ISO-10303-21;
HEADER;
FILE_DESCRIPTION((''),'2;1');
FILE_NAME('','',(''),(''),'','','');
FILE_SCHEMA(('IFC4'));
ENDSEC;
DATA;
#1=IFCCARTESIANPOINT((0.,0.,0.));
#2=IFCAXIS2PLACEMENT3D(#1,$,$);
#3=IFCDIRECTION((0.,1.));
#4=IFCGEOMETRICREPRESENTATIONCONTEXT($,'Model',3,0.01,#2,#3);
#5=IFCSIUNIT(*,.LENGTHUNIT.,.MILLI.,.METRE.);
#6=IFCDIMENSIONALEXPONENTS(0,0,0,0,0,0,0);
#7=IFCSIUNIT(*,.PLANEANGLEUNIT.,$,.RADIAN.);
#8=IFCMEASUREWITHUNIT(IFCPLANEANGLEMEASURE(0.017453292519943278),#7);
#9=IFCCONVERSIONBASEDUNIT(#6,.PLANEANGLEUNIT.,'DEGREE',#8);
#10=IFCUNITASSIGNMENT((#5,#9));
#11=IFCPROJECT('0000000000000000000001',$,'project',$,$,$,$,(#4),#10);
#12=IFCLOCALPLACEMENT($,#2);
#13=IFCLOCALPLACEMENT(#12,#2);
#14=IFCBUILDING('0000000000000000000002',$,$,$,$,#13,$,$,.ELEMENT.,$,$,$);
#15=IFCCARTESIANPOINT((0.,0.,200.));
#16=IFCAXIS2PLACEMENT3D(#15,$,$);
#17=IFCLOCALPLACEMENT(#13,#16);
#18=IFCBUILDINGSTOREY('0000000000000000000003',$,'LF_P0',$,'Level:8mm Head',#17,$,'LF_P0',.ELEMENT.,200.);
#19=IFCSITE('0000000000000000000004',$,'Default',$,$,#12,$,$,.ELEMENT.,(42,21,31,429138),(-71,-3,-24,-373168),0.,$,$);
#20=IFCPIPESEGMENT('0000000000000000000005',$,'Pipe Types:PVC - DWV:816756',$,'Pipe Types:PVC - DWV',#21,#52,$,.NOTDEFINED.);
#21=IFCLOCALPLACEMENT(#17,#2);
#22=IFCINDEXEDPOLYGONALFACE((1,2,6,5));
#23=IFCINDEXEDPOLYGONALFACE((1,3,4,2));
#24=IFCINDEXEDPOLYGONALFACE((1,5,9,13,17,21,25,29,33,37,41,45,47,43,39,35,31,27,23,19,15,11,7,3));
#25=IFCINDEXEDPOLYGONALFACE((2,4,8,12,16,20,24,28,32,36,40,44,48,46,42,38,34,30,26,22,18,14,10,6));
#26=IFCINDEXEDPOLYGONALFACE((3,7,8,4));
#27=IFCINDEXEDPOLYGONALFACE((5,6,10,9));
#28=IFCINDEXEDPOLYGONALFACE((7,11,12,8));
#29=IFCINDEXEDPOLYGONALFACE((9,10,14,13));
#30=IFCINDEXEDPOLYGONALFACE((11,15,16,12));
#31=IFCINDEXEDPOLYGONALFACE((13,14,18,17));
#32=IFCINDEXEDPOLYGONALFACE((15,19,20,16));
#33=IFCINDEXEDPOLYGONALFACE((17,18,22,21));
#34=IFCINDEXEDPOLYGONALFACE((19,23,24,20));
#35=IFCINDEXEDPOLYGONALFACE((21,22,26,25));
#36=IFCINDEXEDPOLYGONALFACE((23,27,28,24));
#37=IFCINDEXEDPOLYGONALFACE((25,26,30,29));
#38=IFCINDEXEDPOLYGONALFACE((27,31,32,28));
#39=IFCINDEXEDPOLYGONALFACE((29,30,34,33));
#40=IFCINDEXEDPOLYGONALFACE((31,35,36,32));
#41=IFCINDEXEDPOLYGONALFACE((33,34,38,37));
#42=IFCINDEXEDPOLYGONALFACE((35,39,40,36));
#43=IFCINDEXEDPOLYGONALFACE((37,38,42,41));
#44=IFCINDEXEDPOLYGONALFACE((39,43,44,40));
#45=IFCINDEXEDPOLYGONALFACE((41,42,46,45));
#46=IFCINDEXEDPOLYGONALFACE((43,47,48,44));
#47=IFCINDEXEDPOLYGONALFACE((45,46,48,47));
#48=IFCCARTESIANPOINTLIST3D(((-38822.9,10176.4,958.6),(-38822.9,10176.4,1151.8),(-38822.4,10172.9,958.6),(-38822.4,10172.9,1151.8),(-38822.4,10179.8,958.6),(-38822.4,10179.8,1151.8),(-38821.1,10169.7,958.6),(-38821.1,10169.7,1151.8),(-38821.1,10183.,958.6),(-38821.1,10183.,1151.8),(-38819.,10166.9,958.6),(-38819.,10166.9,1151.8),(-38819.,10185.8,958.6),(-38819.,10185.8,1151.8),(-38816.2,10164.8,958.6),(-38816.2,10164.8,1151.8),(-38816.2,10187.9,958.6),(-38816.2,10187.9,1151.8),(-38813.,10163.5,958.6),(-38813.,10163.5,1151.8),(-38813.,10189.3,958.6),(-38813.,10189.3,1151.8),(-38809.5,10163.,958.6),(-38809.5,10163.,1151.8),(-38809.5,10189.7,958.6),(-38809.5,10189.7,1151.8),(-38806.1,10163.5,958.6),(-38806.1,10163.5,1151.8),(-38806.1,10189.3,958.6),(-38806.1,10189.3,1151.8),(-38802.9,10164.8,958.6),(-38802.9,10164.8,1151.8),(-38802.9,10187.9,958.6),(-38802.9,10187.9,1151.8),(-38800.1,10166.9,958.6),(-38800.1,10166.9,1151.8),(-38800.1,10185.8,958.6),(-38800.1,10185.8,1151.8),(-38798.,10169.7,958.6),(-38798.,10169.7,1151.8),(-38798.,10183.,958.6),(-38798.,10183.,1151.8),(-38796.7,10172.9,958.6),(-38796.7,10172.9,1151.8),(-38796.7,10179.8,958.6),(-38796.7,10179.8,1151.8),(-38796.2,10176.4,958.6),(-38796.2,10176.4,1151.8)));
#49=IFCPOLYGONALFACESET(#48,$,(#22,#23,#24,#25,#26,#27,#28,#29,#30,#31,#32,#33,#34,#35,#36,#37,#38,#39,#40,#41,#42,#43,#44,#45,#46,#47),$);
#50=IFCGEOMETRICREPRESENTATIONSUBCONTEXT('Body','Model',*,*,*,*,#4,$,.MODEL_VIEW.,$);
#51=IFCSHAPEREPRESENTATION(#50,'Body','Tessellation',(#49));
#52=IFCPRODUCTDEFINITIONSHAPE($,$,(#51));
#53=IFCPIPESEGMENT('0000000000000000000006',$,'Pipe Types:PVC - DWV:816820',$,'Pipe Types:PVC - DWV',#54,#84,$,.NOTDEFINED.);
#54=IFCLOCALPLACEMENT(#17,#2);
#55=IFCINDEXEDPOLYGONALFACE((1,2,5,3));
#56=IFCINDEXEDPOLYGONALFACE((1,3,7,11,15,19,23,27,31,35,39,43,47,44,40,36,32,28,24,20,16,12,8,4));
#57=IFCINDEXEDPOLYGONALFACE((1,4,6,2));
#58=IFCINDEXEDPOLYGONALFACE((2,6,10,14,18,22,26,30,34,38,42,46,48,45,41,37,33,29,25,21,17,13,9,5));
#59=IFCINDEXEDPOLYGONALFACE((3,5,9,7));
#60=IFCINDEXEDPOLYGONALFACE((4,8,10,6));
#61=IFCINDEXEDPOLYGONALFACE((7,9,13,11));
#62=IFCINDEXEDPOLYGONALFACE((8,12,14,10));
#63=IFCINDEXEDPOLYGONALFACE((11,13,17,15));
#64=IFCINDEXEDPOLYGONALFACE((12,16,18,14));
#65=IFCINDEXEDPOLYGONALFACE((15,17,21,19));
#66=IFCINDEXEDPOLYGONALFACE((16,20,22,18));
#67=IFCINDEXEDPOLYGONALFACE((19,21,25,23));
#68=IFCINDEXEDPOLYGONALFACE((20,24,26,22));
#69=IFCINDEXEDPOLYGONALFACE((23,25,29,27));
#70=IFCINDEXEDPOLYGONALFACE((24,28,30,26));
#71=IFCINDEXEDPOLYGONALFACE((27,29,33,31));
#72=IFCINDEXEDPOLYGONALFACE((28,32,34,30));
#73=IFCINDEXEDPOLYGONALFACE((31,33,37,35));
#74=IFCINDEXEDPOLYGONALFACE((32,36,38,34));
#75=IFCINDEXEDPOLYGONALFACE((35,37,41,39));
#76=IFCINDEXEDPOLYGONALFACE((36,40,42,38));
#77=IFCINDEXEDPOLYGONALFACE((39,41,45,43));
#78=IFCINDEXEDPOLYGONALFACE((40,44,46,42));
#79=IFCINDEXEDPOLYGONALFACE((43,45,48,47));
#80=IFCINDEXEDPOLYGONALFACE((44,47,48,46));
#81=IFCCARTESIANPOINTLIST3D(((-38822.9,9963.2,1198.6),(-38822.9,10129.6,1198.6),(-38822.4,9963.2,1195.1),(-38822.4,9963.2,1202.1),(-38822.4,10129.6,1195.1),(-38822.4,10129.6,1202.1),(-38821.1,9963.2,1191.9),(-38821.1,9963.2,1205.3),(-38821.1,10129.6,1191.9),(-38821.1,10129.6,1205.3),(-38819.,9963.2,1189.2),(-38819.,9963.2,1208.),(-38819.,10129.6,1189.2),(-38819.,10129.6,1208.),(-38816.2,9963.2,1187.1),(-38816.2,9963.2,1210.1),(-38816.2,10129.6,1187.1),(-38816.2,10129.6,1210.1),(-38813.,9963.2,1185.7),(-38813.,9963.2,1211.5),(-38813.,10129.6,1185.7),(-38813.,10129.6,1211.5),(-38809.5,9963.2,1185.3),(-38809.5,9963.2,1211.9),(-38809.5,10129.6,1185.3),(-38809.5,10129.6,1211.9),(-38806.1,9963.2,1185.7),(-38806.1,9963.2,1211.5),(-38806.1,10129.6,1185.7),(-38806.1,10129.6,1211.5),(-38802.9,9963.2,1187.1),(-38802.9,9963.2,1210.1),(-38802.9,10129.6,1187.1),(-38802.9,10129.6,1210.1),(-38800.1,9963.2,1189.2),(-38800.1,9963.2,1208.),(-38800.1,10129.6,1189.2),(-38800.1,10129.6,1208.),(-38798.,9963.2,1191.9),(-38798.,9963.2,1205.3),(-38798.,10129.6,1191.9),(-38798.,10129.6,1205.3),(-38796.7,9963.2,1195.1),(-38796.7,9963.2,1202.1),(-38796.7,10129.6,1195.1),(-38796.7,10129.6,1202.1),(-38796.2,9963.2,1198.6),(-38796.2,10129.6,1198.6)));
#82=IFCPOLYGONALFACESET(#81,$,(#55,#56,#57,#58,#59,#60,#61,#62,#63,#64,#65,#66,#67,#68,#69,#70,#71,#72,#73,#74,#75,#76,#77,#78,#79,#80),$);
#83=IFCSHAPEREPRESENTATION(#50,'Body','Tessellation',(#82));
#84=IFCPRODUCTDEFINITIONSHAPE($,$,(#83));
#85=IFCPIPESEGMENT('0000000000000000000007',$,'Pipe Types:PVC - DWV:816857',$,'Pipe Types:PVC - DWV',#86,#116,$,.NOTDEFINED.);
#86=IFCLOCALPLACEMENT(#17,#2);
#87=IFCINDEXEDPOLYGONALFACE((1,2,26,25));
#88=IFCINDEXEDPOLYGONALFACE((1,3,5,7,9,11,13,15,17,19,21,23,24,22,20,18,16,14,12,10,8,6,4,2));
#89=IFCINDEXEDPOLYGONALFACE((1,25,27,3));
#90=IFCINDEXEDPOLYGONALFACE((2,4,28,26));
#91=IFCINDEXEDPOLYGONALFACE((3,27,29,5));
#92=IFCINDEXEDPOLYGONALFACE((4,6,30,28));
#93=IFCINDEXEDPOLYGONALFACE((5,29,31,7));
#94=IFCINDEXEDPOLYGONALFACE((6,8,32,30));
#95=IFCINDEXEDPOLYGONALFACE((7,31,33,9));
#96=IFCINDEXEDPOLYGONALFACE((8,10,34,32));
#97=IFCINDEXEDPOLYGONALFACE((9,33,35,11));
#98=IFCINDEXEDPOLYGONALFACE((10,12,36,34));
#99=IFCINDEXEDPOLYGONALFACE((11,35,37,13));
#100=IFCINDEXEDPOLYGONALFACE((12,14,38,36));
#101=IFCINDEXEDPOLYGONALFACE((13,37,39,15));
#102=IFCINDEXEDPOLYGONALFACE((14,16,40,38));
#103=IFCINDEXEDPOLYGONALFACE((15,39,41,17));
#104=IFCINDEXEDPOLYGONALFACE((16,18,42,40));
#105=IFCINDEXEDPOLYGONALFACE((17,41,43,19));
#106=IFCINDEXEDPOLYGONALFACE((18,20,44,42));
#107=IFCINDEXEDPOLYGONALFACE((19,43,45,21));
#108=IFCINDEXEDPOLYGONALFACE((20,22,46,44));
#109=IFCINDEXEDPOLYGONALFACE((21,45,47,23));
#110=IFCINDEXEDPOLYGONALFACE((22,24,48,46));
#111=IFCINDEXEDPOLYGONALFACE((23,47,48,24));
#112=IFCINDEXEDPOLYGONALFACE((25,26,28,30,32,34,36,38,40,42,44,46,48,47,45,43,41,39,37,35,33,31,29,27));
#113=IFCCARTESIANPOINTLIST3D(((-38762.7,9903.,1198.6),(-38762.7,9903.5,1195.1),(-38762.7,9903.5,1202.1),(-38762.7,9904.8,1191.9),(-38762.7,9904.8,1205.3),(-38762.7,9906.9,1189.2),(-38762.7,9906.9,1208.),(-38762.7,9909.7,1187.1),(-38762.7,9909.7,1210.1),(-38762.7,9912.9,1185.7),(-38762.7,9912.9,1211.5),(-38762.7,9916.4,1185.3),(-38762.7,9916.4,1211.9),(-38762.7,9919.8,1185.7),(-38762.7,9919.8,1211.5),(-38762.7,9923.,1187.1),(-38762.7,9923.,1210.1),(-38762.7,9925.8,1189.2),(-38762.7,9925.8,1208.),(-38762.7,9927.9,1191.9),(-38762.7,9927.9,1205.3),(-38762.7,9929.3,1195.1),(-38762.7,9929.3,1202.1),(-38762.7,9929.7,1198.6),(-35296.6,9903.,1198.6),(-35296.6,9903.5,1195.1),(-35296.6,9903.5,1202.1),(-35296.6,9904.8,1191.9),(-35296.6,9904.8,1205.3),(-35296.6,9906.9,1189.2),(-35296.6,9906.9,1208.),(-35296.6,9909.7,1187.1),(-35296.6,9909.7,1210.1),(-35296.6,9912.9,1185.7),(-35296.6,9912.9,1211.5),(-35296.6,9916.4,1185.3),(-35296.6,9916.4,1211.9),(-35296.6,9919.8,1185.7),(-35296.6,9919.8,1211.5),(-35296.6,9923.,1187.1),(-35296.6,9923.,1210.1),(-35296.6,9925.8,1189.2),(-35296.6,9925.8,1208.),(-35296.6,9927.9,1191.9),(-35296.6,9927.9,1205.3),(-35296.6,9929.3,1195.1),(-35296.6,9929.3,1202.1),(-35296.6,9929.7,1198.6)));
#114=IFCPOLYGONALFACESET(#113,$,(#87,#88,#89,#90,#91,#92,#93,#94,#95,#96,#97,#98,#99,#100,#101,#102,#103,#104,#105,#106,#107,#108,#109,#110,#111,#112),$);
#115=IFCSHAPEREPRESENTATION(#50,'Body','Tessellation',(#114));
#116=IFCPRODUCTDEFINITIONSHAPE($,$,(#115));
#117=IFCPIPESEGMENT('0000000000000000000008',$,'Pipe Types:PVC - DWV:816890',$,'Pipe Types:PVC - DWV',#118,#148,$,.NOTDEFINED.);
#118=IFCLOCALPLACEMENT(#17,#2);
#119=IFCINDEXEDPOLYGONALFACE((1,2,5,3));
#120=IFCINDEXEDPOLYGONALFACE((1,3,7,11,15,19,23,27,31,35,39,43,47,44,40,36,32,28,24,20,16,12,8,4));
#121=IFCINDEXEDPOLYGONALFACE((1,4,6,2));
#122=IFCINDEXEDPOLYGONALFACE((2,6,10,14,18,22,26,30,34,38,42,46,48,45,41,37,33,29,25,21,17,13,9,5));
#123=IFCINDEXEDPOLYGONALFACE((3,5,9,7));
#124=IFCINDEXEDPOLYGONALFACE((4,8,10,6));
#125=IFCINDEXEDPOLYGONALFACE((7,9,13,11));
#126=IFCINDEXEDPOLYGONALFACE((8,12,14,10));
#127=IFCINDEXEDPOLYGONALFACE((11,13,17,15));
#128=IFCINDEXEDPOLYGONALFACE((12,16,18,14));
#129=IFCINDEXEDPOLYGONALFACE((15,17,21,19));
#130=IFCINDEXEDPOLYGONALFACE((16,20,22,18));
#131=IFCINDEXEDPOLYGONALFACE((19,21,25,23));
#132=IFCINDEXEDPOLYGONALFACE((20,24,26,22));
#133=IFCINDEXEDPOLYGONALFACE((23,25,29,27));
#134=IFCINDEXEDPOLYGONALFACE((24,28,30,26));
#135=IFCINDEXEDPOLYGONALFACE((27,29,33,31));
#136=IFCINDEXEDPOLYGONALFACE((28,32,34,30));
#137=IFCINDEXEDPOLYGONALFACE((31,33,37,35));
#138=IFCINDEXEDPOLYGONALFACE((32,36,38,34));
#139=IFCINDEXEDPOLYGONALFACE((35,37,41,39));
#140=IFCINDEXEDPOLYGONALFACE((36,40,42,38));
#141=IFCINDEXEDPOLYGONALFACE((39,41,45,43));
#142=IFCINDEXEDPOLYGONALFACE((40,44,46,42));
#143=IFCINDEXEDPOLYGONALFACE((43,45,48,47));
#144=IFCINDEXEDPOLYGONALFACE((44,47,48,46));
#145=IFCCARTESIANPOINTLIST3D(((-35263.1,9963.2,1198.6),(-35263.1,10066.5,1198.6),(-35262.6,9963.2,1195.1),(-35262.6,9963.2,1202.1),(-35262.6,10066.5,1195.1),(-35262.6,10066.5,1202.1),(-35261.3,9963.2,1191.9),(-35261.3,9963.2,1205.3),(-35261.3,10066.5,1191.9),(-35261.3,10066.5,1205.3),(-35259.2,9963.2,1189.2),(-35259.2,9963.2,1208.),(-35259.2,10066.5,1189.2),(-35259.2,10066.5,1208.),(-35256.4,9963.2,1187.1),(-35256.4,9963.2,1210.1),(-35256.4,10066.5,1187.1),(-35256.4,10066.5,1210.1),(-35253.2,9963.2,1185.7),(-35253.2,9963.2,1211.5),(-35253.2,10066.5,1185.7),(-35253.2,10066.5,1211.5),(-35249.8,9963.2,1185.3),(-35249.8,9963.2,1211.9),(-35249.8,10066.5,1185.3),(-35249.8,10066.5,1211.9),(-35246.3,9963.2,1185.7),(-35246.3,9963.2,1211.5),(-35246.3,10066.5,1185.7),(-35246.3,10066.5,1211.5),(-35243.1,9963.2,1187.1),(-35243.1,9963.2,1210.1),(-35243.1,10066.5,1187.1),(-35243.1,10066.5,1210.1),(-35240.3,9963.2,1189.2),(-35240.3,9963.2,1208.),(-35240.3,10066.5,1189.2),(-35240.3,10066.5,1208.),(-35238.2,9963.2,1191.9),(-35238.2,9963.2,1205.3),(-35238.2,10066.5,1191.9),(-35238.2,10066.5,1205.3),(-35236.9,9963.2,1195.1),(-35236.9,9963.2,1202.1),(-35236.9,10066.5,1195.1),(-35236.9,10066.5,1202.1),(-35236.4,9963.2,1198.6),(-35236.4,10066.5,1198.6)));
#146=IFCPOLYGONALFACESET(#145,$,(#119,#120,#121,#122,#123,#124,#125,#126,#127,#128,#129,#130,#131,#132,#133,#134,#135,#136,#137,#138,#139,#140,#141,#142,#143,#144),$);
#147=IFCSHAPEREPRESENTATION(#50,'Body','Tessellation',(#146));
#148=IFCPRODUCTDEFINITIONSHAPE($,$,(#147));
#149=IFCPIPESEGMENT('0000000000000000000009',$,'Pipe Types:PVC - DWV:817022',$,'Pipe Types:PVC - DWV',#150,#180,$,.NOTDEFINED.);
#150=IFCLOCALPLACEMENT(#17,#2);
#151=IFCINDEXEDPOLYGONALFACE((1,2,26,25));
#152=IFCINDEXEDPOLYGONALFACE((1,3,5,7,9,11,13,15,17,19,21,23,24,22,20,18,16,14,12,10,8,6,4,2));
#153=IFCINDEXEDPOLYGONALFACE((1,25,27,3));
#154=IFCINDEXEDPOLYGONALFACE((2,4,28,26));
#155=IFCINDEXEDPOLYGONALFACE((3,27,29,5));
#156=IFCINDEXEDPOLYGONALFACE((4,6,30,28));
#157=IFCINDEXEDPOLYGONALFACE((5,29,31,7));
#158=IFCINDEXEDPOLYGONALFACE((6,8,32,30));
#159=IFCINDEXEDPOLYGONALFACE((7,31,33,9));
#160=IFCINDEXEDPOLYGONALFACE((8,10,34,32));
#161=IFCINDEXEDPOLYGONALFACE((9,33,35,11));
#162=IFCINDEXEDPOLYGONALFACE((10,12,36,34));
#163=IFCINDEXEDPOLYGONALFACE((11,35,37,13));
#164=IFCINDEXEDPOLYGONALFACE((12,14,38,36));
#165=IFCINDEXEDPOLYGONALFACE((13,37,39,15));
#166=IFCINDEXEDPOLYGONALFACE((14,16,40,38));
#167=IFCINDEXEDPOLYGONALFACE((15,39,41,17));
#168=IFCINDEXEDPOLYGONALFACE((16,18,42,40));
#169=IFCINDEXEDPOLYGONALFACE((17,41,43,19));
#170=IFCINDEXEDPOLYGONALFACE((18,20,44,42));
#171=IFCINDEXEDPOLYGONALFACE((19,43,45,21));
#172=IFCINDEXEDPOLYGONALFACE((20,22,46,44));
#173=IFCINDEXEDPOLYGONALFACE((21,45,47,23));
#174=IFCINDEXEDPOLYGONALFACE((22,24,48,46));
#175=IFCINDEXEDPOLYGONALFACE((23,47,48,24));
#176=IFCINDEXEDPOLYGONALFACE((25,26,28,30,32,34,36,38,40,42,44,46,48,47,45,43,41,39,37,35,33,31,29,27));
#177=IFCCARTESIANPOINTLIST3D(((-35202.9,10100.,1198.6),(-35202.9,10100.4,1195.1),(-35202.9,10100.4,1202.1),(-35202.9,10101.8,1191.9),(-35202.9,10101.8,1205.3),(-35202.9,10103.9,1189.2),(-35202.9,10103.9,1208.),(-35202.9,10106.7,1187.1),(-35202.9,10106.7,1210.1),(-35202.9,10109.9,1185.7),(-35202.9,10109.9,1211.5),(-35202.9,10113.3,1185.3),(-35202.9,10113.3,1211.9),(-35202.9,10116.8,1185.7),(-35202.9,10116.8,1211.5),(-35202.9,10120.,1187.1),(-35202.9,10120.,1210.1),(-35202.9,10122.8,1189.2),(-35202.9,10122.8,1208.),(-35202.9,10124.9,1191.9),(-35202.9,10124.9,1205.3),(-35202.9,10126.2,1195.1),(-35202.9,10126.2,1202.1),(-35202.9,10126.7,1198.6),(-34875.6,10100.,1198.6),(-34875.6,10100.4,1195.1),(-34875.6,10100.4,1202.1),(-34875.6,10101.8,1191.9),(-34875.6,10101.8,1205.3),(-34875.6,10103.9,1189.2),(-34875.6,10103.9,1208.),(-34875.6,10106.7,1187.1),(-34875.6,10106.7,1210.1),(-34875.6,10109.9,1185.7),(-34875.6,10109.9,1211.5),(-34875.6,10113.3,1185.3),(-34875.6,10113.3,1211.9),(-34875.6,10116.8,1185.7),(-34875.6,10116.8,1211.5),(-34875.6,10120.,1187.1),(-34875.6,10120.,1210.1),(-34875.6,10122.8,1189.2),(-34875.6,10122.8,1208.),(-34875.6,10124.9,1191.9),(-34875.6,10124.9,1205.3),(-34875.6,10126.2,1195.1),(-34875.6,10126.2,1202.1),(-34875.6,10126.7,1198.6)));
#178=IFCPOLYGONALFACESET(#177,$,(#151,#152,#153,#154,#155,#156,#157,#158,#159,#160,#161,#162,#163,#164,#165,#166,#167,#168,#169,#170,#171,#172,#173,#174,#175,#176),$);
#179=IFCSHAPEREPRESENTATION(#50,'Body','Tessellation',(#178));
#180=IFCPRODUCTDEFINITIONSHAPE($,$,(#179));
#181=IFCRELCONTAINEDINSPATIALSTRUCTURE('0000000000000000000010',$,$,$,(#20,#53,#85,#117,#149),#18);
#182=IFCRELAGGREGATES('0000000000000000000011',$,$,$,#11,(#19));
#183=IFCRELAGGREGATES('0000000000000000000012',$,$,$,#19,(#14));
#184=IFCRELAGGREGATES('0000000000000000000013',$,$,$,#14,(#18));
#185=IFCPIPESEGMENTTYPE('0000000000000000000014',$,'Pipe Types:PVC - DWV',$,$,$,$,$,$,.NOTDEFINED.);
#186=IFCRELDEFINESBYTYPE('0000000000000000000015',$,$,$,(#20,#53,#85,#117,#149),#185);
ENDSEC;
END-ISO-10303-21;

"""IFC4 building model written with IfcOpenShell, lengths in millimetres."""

from ifc_helpers import new_model, entity, si_unit, converted_unit, direction, frame, origin, place, context, subcontext, project, spatial, arc, indexed_curve, outline, extrude, type_object, element, save


model = new_model("IFC4")

# Units and contexts
model_context = context("Model", 3, precision=0.01, world=origin(), true_north=direction((0.0, 1.0)))
body_context = subcontext(model_context, "Body", "Model", "MODEL_VIEW")
ifc_project = project(units=[si_unit("LENGTHUNIT", "METRE", prefix="MILLI"), converted_unit("PLANEANGLEUNIT", "DEGREE", entity("IfcPlaneAngleMeasure", 0.017453292519943278), si_unit("PLANEANGLEUNIT", "RADIAN"), dimensions=[0, 0, 0, 0, 0, 0, 0])], contexts=[model_context])

# Site, building, storey
site_placement = place(None, origin())
site = spatial("IfcSite", under=ifc_project, at=site_placement, Name="Default", CompositionType="ELEMENT", RefLatitude=(42, 21, 31, 429138), RefLongitude=(-71, -3, -24, -373168), RefElevation=0.0)
building_placement = place(site_placement, origin())
building = spatial("IfcBuilding", under=site, at=building_placement, CompositionType="ELEMENT")
storey_placement = place(building_placement, frame((0.0, 0.0, 200.0)))
storey = spatial("IfcBuildingStorey", under=building, at=storey_placement, Name="LF_P0", ObjectType="Level:8mm Head", LongName="LF_P0", CompositionType="ELEMENT", Elevation=200.0)

# Pipe segments
pipe_segment_type_1 = type_object("IfcPipeSegmentType", Name="Pipe Types:PVC - DWV", PredefinedType="NOTDEFINED")
pipe_segment_1_placement = place(storey_placement, origin())
element("IfcPipeSegment", 1, at=pipe_segment_1_placement, inside=storey, type_object=pipe_segment_type_1, Name="Pipe Types:PVC - DWV:816756", ObjectType="Pipe Types:PVC - DWV", PredefinedType="NOTDEFINED", context=body_context, shape_type="SweptSolid", body=[
    extrude(outline(indexed_curve([(13.3, 0.0), (9.4, 9.4), (0.0, 13.3), (-9.4, 9.4), (-13.3, 0.0), (-9.4, -9.4), (0.0, -13.3), (9.4, -9.4)], segments=[arc(1, 2, 3), arc(3, 4, 5), arc(5, 6, 7), arc(7, 8, 1)], self_intersect=False)), frame((-38809.5, 10176.4, 958.6), z_axis=(0.0, 0.0, 1.0), x_axis=(-1.0, 0.0, 0.0)), (0.0, 0.0, 1.0), 193.2),
])
pipe_segment_2_placement = place(storey_placement, origin())
element("IfcPipeSegment", 2, at=pipe_segment_2_placement, inside=storey, type_object=pipe_segment_type_1, Name="Pipe Types:PVC - DWV:816820", ObjectType="Pipe Types:PVC - DWV", PredefinedType="NOTDEFINED", context=body_context, shape_type="SweptSolid", body=[
    extrude(outline(indexed_curve([(13.3, 0.0), (9.4, 9.4), (0.0, 13.3), (-9.4, 9.4), (-13.3, 0.0), (-9.4, -9.4), (0.0, -13.3), (9.4, -9.4)], segments=[arc(1, 2, 3), arc(3, 4, 5), arc(5, 6, 7), arc(7, 8, 1)], self_intersect=False)), frame((-38809.5, 9963.2, 1198.6), z_axis=(0.0, 1.0, 0.0), x_axis=(-1.0, 0.0, 0.0)), (0.0, 0.0, 1.0), 166.4),
])
pipe_segment_3_placement = place(storey_placement, origin())
element("IfcPipeSegment", 3, at=pipe_segment_3_placement, inside=storey, type_object=pipe_segment_type_1, Name="Pipe Types:PVC - DWV:816857", ObjectType="Pipe Types:PVC - DWV", PredefinedType="NOTDEFINED", context=body_context, shape_type="SweptSolid", body=[
    extrude(outline(indexed_curve([(13.3, 0.0), (9.4, 9.4), (0.0, 13.3), (-9.4, 9.4), (-13.3, 0.0), (-9.4, -9.4), (0.0, -13.3), (9.4, -9.4)], segments=[arc(1, 2, 3), arc(3, 4, 5), arc(5, 6, 7), arc(7, 8, 1)], self_intersect=False)), frame((-38762.7, 9916.4, 1198.6), z_axis=(1.0, 0.0, 0.0), x_axis=(0.0, -1.0, 0.0)), (0.0, 0.0, 1.0), 3466.2),
])
pipe_segment_4_placement = place(storey_placement, origin())
element("IfcPipeSegment", 4, at=pipe_segment_4_placement, inside=storey, type_object=pipe_segment_type_1, Name="Pipe Types:PVC - DWV:816890", ObjectType="Pipe Types:PVC - DWV", PredefinedType="NOTDEFINED", context=body_context, shape_type="SweptSolid", body=[
    extrude(outline(indexed_curve([(13.3, 0.0), (9.4, 9.4), (0.0, 13.3), (-9.4, 9.4), (-13.3, 0.0), (-9.4, -9.4), (0.0, -13.3), (9.4, -9.4)], segments=[arc(1, 2, 3), arc(3, 4, 5), arc(5, 6, 7), arc(7, 8, 1)], self_intersect=False)), frame((-35249.8, 9963.2, 1198.6), z_axis=(0.0, 1.0, 0.0), x_axis=(1.0, 0.0, 0.0)), (0.0, 0.0, 1.0), 103.3),
])
pipe_segment_5_placement = place(storey_placement, origin())
element("IfcPipeSegment", 5, at=pipe_segment_5_placement, inside=storey, type_object=pipe_segment_type_1, Name="Pipe Types:PVC - DWV:817022", ObjectType="Pipe Types:PVC - DWV", PredefinedType="NOTDEFINED", context=body_context, shape_type="SweptSolid", body=[
    extrude(outline(indexed_curve([(13.3, 0.0), (9.4, 9.4), (0.0, 13.3), (-9.4, 9.4), (-13.3, 0.0), (-9.4, -9.4), (0.0, -13.3), (9.4, -9.4)], segments=[arc(1, 2, 3), arc(3, 4, 5), arc(5, 6, 7), arc(7, 8, 1)], self_intersect=False)), frame((-35202.9, 10113.3, 1198.6), z_axis=(1.0, 0.0, 0.0), x_axis=(0.0, -1.0, 0.0)), (0.0, 0.0, 1.0), 327.4),
])

save(model, "model.ifc")
